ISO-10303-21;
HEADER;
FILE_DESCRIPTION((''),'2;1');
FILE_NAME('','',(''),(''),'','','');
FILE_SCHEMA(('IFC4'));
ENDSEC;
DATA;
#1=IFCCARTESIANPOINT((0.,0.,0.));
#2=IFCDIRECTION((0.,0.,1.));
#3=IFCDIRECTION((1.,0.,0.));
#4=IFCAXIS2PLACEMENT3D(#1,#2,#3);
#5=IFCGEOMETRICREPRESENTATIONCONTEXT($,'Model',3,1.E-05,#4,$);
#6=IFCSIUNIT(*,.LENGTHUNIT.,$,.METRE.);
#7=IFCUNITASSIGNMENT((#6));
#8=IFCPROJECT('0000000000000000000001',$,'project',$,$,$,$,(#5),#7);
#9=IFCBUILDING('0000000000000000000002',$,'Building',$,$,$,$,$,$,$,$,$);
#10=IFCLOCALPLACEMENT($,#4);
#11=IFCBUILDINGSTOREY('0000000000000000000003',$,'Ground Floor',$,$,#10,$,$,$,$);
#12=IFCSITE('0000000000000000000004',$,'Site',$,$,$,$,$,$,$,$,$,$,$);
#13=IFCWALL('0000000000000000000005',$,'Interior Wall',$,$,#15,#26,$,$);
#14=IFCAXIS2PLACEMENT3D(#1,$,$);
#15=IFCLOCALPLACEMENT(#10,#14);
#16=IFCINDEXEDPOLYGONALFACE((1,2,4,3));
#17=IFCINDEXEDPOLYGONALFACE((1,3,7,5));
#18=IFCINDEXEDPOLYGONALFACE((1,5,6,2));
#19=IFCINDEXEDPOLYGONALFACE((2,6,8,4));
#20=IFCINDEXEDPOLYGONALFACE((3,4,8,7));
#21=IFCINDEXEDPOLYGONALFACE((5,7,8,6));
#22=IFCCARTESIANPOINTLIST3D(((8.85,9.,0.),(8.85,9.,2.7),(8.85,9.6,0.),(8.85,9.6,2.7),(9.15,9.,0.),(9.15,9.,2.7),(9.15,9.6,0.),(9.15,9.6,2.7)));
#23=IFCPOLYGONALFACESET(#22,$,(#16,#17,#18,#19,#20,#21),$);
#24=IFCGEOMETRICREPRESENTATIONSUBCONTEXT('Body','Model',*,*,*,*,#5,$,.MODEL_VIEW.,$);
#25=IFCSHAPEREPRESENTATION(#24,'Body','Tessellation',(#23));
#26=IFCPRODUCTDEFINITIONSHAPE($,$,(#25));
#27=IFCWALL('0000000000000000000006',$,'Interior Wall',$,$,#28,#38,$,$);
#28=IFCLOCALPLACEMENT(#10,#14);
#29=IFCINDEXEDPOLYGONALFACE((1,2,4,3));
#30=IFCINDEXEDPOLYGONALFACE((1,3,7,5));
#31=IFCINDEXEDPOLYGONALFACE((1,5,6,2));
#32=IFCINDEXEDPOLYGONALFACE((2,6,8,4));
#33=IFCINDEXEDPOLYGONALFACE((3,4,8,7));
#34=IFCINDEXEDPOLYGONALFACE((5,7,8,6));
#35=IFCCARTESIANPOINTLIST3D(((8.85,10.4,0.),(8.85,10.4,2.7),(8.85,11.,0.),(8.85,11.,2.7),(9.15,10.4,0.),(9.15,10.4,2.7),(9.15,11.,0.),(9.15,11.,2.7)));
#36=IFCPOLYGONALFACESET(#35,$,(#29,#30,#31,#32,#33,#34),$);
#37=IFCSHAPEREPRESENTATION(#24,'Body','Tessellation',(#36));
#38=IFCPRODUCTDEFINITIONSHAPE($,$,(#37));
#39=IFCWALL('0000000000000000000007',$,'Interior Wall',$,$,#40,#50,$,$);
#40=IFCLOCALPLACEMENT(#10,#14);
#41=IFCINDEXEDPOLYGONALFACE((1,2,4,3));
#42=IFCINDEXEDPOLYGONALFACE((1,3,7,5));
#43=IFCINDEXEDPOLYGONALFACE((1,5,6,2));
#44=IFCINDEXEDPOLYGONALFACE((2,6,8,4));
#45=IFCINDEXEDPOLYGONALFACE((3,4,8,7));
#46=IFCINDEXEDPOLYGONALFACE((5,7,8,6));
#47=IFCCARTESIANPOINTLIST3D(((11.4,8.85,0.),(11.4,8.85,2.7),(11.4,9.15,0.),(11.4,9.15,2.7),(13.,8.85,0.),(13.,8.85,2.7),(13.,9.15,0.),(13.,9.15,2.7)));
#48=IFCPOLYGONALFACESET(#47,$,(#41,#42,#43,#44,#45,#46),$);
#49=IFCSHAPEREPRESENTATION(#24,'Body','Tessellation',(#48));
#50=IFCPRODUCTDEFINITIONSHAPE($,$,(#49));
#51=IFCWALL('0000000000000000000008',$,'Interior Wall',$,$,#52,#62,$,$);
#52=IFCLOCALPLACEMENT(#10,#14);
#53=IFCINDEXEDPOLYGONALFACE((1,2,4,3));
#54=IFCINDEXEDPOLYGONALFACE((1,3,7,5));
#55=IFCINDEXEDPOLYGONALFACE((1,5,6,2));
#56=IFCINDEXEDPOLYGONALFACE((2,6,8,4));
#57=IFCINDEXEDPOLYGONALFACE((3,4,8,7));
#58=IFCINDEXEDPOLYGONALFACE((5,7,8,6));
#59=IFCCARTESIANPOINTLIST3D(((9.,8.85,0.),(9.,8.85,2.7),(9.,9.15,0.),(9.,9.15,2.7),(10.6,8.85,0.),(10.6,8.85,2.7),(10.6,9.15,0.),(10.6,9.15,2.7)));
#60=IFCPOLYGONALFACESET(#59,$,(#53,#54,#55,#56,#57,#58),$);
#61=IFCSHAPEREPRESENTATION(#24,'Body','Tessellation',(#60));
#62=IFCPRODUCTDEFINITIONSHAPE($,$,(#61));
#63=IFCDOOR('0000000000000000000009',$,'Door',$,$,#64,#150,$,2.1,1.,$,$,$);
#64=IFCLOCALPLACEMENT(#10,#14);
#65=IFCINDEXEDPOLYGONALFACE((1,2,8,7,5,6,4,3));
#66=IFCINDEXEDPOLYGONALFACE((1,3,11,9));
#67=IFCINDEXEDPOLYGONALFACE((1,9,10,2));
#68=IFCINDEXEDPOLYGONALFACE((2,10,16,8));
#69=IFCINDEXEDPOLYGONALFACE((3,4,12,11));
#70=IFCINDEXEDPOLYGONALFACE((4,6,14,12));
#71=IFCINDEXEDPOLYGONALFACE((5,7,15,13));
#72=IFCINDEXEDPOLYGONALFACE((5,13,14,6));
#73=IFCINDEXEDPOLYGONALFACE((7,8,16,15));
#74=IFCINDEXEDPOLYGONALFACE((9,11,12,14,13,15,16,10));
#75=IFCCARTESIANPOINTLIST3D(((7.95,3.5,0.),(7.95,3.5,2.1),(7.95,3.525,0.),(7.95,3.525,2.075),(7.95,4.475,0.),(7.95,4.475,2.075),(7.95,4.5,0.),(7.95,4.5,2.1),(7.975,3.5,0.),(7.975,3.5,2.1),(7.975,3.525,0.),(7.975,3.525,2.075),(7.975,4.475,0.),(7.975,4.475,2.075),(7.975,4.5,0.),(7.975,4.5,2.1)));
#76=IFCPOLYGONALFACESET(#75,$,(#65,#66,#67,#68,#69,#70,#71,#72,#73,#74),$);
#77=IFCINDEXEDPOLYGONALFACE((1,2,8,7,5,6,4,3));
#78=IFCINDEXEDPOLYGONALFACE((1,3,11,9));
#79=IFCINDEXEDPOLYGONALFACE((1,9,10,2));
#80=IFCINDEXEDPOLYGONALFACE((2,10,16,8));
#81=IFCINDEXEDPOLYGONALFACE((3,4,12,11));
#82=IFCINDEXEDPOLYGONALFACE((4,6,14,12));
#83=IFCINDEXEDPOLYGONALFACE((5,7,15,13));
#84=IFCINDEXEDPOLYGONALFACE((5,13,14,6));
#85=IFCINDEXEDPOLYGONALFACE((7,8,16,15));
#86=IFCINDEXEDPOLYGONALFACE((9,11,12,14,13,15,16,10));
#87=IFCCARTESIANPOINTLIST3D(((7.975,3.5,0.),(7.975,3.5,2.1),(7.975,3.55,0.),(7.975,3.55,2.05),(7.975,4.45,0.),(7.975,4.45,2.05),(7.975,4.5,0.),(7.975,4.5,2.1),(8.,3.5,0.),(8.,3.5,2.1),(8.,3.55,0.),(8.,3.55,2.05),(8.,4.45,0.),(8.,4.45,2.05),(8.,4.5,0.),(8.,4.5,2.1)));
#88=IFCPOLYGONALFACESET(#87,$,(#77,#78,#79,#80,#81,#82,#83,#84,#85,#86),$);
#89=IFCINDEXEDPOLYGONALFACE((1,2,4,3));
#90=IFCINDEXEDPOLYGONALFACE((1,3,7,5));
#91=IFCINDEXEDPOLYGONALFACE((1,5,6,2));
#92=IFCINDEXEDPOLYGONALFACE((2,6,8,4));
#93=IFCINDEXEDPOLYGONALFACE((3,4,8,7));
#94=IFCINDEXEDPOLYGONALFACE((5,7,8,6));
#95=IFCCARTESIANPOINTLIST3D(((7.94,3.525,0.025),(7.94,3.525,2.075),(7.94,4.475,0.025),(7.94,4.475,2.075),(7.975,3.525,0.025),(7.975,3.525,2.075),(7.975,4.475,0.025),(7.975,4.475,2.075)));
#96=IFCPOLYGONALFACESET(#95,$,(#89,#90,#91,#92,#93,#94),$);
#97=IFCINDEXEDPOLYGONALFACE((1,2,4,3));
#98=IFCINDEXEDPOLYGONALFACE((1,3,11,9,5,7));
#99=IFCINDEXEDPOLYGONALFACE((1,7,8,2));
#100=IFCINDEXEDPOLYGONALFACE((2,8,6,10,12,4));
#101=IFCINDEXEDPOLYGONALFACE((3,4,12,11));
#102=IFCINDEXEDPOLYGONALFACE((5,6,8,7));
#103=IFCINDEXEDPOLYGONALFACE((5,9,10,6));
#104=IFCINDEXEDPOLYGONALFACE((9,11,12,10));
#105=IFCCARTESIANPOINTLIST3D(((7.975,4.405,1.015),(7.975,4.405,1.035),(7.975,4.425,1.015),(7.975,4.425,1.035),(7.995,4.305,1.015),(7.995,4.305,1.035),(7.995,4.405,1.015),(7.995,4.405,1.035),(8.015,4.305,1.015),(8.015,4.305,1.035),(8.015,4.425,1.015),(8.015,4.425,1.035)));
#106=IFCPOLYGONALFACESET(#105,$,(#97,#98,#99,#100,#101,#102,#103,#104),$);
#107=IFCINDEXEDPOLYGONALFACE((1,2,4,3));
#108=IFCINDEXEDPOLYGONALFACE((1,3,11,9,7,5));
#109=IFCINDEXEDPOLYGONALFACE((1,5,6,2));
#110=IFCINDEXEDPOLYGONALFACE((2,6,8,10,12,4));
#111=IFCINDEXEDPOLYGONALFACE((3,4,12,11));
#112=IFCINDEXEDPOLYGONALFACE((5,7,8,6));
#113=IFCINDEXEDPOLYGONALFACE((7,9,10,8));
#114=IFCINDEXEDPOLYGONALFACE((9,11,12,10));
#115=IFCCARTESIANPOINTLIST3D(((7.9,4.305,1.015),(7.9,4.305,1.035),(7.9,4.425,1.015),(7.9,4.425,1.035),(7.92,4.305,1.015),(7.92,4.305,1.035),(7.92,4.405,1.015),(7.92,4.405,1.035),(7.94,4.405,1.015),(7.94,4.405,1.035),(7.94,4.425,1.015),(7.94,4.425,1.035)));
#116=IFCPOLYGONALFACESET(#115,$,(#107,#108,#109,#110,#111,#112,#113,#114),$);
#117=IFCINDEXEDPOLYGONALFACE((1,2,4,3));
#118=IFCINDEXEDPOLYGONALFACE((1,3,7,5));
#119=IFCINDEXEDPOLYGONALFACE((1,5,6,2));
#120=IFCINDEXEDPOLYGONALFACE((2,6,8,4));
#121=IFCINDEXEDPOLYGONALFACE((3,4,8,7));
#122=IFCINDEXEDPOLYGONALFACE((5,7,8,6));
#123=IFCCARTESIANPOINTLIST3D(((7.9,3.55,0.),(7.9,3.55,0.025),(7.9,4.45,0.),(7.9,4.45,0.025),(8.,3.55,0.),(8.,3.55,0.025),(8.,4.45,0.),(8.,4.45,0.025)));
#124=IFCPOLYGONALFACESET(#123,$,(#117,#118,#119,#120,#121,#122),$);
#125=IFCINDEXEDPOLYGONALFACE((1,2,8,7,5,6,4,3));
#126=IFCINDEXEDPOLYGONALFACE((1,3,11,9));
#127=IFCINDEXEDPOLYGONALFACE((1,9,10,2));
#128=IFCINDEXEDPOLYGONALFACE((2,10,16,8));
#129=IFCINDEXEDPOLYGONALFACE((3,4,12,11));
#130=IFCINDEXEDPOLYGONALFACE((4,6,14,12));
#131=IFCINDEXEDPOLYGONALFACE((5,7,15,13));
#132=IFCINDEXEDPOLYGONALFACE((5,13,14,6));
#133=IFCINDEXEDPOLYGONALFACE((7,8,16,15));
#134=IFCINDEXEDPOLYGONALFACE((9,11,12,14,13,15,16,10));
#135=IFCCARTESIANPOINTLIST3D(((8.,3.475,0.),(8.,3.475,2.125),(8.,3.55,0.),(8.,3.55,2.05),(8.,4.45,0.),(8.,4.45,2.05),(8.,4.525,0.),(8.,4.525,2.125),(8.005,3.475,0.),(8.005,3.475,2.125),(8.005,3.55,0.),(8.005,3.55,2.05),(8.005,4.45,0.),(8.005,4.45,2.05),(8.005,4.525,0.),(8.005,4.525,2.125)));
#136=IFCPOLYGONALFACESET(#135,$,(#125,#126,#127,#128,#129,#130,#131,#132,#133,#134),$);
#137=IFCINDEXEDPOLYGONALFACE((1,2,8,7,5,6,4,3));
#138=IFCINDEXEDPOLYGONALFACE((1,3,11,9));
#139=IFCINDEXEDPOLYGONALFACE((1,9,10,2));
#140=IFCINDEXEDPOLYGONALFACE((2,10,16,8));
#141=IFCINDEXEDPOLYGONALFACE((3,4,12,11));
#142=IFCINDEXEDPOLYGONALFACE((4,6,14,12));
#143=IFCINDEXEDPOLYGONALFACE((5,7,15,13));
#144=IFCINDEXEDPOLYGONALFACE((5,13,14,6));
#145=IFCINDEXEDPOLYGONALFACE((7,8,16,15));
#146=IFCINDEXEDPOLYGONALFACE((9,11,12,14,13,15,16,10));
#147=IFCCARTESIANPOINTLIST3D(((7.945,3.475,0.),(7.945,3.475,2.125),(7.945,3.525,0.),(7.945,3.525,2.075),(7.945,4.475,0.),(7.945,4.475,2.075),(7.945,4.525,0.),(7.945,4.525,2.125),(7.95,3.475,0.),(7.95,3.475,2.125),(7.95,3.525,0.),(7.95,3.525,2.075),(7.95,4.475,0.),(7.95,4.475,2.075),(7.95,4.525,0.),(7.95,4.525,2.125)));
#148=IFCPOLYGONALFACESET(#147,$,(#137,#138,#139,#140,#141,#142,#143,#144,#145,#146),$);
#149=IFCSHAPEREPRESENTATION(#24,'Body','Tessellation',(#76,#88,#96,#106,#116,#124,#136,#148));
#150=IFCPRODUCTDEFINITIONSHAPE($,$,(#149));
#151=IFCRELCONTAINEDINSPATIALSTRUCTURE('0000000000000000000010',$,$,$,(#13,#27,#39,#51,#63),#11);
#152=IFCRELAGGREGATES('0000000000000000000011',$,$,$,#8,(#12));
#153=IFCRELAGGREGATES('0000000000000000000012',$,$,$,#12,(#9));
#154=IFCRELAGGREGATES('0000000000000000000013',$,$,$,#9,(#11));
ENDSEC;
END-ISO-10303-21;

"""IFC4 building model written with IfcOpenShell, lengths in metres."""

from ifc_helpers import new_model, si_unit, frame, origin_with_axes, place, context, subcontext, project, spatial, line, indexed_curve, outline, extrude, element, save


model = new_model("IFC4")

# Units and contexts
model_context = context("Model", 3, precision=1e-05, world=origin_with_axes())
body_context = subcontext(model_context, "Body", "Model", "MODEL_VIEW")
ifc_project = project(units=[si_unit("LENGTHUNIT", "METRE")], contexts=[model_context])

# Site, building, storey
site = spatial("IfcSite", under=ifc_project, Name="Site")
building = spatial("IfcBuilding", under=site, Name="Building")
storey_placement = place(None, origin_with_axes())
storey = spatial("IfcBuildingStorey", under=building, at=storey_placement, Name="Ground Floor")

# Walls
for number, where, z_axis, x_axis, name in (
    (1, (9.0, 9.0, 0.0), (0.0, 0.0, 1.0), (0.0, 1.0, 0.0), "Interior Wall"),
    (2, (9.0, 10.4, 0.0), (0.0, 0.0, 1.0), (0.0, 1.0, 0.0), "Interior Wall"),
):
    element("IfcWall", number, at=place(storey_placement, frame(where, z_axis=z_axis, x_axis=x_axis)), inside=storey, Name=name, context=body_context, shape_type="SweptSolid", body=[
        extrude(outline(indexed_curve([(0.0, 0.0), (0.0, 0.3), (0.6, 0.3), (0.6, 0.0), (0.0, 0.0)], self_intersect=False)), frame((0.0, -0.15, 0.0), z_axis=(0.0, 0.0, 1.0), x_axis=(1.0, 0.0, 0.0)), (0.0, 0.0, 1.0), 2.7),
    ])
for number, where, z_axis, x_axis, name in (
    (3, (13.0, 9.0, 0.0), (0.0, 0.0, 1.0), (-1.0, 0.0, 0.0), "Interior Wall"),
    (4, (10.6, 9.0, 0.0), (0.0, 0.0, 1.0), (-1.0, 0.0, 0.0), "Interior Wall"),
):
    element("IfcWall", number, at=place(storey_placement, frame(where, z_axis=z_axis, x_axis=x_axis)), inside=storey, Name=name, context=body_context, shape_type="SweptSolid", body=[
        extrude(outline(indexed_curve([(0.0, 0.0), (0.0, 0.3), (1.6, 0.3), (1.6, 0.0), (0.0, 0.0)], self_intersect=False)), frame((0.0, -0.15, 0.0), z_axis=(0.0, 0.0, 1.0), x_axis=(1.0, 0.0, 0.0)), (0.0, 0.0, 1.0), 2.7),
    ])

# Door
door_1_placement = place(storey_placement, frame((8.0, 3.5, 0.0), z_axis=(0.0, 0.0, 1.0), x_axis=(0.0, 1.0, 0.0)))
element("IfcDoor", 5, at=door_1_placement, inside=storey, Name="Door", OverallHeight=2.1, OverallWidth=1.0, context=body_context, shape_type="SweptSolid", body=[
    extrude(outline(indexed_curve([(0.0, 0.0), (0.0, 2.1), (1.0, 2.1), (1.0, 0.0), (0.975, 0.0), (0.975, 2.075), (0.025, 2.075), (0.025, 0.0)], segments=[line(1, 2, 3, 4, 5, 6, 7, 8, 1)])), frame((0.0, 0.025, 0.0), z_axis=(0.0, -1.0, 0.0), x_axis=(1.0, 0.0, 0.0)), (0.0, 0.0, -1.0), 0.025),
    extrude(outline(indexed_curve([(0.0, 0.0), (0.0, 2.1), (1.0, 2.1), (1.0, 0.0), (0.95, 0.0), (0.95, 2.05), (0.05, 2.05), (0.05, 0.0)], segments=[line(1, 2, 3, 4, 5, 6, 7, 8, 1)])), frame((0.0, 0.0, 0.0), z_axis=(0.0, -1.0, 0.0), x_axis=(1.0, 0.0, 0.0)), (0.0, 0.0, -1.0), 0.025),
    extrude(outline(indexed_curve([(0.0, 0.0), (0.95, 0.0), (0.95, 0.035), (0.0, 0.035)], segments=[line(1, 2, 3, 4, 1)])), frame((0.025, 0.025, 0.025), z_axis=(0.0, 0.0, 1.0), x_axis=(1.0, 0.0, 0.0)), (0.0, 0.0, 1.0), 2.05),
    extrude(outline(indexed_curve([(0.0, 0.0), (0.0, -0.04), (-0.12, -0.04), (-0.12, -0.02), (-0.02, -0.02), (-0.02, 0.0)], segments=[line(1, 2, 3, 4, 5, 6, 1)])), frame((0.925, 0.025, 1.015), z_axis=(0.0, 0.0, 1.0), x_axis=(1.0, 0.0, 0.0)), (0.0, 0.0, 1.0), 0.02),
    extrude(outline(indexed_curve([(0.0, 0.0), (0.0, 0.04), (-0.12, 0.04), (-0.12, 0.02), (-0.02, 0.02), (-0.02, 0.0)], segments=[line(1, 2, 3, 4, 5, 6, 1)])), frame((0.925, 0.06, 1.015), z_axis=(0.0, 0.0, 1.0), x_axis=(1.0, 0.0, 0.0)), (0.0, 0.0, 1.0), 0.02),
    extrude(outline(indexed_curve([(0.0, 0.0), (0.9, 0.0), (0.9, 0.1), (0.0, 0.1)], segments=[line(1, 2, 3, 4, 1)])), frame((0.05, 0.0, 0.0), z_axis=(0.0, 0.0, 1.0), x_axis=(1.0, 0.0, 0.0)), (0.0, 0.0, 1.0), 0.025),
    extrude(outline(indexed_curve([(0.0, 0.0), (0.0, 2.125), (1.05, 2.125), (1.05, 0.0), (0.975, 0.0), (0.975, 2.05), (0.075, 2.05), (0.075, 0.0)], segments=[line(1, 2, 3, 4, 5, 6, 7, 8, 1)])), frame((-0.025, -0.005, 0.0), z_axis=(0.0, -1.0, 0.0), x_axis=(1.0, 0.0, 0.0)), (0.0, 0.0, -1.0), 0.005),
    extrude(outline(indexed_curve([(0.0, 0.0), (0.0, 2.125), (1.05, 2.125), (1.05, 0.0), (1.0, 0.0), (1.0, 2.075), (0.05, 2.075), (0.05, 0.0)], segments=[line(1, 2, 3, 4, 5, 6, 7, 8, 1)])), frame((-0.025, 0.05, 0.0), z_axis=(0.0, -1.0, 0.0), x_axis=(1.0, 0.0, 0.0)), (0.0, 0.0, -1.0), 0.005),
])

save(model, "model.ifc")
